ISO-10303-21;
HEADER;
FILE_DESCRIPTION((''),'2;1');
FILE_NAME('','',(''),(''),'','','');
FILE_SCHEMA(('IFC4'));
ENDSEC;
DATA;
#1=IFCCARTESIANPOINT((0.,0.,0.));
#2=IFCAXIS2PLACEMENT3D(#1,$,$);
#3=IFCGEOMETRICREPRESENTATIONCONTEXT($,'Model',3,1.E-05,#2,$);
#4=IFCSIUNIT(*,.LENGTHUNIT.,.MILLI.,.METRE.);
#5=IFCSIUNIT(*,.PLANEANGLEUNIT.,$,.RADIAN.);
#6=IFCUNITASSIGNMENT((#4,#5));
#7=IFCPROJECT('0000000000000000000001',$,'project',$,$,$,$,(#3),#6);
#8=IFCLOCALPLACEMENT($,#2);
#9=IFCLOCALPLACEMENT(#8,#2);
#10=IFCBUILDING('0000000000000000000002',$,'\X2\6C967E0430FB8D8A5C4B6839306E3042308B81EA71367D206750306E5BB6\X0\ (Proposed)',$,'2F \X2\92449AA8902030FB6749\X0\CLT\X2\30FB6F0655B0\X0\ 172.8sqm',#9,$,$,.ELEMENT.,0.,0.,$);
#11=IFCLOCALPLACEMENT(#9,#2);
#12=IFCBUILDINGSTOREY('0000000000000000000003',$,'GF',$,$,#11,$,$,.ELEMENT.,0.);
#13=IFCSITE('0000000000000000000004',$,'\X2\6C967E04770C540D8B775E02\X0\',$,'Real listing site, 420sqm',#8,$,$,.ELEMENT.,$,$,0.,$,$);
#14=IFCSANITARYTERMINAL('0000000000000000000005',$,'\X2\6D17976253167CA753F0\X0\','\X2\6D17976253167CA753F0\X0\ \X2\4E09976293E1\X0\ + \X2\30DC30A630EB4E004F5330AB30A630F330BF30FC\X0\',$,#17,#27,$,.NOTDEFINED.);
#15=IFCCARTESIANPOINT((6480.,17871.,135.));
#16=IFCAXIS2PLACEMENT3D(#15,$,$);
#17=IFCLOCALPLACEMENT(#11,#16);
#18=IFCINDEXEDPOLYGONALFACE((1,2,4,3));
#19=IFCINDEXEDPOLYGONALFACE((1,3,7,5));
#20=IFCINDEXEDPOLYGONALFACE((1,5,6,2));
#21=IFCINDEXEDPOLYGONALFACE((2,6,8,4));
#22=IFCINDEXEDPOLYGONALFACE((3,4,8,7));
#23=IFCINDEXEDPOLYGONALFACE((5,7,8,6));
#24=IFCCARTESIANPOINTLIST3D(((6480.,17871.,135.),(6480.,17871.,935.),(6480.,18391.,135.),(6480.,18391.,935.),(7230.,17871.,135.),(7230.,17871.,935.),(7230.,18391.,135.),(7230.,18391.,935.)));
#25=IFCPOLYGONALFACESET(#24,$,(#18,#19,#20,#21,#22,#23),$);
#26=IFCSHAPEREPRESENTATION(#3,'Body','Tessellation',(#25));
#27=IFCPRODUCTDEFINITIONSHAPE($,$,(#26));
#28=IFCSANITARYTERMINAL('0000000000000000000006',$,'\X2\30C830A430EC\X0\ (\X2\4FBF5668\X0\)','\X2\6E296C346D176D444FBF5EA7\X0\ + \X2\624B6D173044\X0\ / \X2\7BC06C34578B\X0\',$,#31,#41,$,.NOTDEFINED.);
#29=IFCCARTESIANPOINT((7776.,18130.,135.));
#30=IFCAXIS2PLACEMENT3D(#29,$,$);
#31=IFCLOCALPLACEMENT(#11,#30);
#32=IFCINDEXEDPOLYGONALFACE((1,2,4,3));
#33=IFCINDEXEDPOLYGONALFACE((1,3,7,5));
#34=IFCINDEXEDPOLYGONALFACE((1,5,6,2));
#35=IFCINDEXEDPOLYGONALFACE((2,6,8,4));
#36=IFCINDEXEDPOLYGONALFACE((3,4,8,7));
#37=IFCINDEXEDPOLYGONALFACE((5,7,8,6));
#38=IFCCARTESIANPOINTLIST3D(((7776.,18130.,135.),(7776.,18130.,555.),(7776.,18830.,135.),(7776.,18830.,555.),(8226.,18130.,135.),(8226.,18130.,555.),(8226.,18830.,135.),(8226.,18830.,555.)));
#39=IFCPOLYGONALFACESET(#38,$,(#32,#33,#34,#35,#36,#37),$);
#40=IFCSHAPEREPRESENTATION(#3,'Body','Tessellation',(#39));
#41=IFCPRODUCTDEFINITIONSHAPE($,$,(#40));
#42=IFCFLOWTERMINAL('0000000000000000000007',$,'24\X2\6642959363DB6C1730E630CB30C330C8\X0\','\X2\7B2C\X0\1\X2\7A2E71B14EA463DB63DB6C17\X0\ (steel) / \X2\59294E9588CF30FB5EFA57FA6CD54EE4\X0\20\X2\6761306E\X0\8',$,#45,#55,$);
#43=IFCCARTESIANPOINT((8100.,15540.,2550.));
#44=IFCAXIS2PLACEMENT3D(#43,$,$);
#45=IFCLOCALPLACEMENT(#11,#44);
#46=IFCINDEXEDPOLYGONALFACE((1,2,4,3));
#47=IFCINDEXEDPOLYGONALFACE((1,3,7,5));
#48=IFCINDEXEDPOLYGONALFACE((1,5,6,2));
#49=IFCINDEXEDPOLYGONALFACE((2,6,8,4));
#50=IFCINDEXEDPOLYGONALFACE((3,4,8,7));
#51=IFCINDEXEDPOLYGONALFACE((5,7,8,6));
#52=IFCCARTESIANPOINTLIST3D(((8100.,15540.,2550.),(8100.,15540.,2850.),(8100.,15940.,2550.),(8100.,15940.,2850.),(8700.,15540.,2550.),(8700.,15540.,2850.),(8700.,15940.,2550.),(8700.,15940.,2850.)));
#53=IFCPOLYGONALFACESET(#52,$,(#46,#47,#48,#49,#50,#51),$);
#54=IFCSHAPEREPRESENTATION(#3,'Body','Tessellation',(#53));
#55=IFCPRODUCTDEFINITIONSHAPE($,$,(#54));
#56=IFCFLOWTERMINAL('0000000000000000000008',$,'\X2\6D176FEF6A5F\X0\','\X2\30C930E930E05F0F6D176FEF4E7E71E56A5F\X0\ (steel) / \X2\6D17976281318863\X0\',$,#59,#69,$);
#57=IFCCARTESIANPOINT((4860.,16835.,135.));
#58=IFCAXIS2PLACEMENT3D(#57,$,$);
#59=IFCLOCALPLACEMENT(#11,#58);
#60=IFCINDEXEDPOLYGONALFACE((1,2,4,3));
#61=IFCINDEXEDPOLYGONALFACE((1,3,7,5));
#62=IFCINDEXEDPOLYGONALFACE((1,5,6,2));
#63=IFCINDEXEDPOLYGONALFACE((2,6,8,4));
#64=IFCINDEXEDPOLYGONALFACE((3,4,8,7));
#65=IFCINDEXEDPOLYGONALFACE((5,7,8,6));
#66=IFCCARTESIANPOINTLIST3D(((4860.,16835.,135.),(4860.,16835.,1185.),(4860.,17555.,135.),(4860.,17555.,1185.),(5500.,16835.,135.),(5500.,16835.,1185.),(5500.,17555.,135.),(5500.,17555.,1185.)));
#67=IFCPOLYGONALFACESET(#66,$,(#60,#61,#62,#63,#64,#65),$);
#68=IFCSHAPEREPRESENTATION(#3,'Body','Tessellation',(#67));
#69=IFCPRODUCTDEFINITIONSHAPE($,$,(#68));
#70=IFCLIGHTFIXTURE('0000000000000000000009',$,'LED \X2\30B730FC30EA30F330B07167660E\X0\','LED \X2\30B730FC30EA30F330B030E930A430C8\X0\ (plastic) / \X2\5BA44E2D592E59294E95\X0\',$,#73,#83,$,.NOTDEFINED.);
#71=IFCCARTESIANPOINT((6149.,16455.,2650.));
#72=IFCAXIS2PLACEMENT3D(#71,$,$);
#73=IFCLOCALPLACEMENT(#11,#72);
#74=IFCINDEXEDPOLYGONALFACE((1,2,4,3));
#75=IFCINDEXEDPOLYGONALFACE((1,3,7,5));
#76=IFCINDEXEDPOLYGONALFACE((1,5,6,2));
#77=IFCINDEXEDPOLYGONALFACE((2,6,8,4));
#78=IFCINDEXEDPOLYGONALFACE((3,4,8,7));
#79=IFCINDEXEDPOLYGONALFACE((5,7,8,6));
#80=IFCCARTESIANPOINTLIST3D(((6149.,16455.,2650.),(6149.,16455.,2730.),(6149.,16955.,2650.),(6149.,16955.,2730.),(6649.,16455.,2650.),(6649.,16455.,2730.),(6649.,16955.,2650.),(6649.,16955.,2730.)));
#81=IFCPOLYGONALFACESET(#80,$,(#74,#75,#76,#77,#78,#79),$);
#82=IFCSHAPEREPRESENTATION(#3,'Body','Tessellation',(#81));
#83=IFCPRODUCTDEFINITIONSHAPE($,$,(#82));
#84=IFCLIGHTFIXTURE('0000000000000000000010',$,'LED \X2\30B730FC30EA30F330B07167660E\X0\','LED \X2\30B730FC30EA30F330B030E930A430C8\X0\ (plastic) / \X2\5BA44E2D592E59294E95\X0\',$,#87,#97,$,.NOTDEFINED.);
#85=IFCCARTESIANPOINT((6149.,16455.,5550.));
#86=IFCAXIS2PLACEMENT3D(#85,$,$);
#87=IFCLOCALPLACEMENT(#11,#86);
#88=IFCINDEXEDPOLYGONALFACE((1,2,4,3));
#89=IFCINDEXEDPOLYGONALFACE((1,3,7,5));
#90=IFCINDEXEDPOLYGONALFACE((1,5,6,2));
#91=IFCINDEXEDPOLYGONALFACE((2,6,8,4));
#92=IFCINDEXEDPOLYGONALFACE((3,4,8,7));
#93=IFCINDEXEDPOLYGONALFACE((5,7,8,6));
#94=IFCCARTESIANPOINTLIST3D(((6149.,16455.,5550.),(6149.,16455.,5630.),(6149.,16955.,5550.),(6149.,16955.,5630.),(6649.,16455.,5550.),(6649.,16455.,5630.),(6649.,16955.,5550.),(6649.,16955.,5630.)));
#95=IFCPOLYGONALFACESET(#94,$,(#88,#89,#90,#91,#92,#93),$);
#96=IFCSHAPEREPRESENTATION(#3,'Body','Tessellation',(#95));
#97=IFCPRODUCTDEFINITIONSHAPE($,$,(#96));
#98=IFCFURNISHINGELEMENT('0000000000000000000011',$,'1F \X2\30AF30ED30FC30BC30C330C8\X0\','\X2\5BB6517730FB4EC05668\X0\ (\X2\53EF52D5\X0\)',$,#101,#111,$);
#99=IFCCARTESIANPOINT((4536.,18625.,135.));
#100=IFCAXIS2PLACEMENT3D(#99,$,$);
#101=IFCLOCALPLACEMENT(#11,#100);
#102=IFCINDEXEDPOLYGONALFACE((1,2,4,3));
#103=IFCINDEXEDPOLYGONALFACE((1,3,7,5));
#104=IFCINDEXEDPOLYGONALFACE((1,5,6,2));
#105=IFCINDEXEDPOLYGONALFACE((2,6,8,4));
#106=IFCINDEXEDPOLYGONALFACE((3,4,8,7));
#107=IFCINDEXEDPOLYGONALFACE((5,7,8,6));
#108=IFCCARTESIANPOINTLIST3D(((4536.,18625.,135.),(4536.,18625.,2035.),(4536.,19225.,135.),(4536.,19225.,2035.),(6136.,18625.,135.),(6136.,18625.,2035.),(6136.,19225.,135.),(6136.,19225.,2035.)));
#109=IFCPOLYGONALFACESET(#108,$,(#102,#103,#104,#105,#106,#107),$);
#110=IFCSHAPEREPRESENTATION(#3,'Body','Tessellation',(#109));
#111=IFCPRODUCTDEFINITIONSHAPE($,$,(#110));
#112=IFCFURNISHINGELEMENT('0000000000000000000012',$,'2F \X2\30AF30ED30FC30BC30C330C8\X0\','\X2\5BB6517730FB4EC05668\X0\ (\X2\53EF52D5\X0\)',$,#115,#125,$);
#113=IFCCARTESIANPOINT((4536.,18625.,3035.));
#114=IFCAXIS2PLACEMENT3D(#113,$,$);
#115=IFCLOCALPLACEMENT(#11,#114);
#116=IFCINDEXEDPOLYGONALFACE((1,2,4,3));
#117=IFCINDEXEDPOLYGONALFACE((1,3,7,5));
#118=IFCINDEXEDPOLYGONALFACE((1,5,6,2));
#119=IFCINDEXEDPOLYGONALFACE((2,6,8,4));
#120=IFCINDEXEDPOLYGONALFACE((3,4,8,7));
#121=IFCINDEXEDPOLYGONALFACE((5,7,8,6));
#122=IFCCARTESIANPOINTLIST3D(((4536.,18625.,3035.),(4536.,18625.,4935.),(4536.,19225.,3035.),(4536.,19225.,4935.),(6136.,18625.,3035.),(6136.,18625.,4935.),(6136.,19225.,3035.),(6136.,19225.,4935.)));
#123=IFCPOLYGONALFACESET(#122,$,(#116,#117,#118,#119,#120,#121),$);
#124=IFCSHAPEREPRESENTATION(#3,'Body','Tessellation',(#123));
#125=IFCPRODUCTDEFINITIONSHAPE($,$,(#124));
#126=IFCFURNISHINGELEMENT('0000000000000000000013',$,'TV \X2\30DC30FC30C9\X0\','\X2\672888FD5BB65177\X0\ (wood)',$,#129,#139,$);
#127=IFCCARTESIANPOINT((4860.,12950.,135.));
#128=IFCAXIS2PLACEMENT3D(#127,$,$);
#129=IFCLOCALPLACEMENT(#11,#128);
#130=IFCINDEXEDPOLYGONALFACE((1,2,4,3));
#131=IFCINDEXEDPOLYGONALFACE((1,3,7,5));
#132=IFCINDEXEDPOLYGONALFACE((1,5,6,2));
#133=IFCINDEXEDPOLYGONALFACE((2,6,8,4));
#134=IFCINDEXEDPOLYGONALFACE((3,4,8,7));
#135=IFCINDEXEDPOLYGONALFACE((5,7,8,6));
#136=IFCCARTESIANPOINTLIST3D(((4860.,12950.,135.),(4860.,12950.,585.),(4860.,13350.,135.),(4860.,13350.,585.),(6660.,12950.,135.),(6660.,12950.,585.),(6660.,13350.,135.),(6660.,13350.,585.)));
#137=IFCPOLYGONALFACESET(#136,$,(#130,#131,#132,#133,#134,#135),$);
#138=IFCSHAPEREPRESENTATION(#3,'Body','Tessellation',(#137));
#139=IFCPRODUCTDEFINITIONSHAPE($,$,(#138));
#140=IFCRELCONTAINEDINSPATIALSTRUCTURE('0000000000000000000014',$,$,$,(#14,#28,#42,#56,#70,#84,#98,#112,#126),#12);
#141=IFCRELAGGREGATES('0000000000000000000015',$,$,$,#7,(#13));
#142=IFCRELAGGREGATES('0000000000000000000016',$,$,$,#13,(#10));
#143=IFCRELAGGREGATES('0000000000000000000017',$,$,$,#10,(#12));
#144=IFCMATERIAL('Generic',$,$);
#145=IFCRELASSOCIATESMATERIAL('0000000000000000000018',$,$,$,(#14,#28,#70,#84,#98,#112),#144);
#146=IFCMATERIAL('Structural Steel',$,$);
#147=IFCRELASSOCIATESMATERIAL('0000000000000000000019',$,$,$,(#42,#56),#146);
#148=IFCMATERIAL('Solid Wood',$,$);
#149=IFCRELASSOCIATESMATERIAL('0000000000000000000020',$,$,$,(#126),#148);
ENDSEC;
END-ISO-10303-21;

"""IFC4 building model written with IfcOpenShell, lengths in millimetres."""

from ifc_helpers import new_model, si_unit, frame, frame_2d, origin, place, context, project, spatial, rectangle, extrude, material, element, save


model = new_model("IFC4")

# Units and contexts
model_context = context("Model", 3, precision=1e-05, world=origin())
ifc_project = project(units=[si_unit("LENGTHUNIT", "METRE", prefix="MILLI"), si_unit("PLANEANGLEUNIT", "RADIAN")], contexts=[model_context])

# Site, building, storey
site_placement = place(None, origin())
site = spatial("IfcSite", under=ifc_project, at=site_placement, Name="沖縄県名護市", ObjectType="Real listing site, 420sqm", CompositionType="ELEMENT", RefElevation=0.0)
building_placement = place(site_placement, origin())
building = spatial("IfcBuilding", under=site, at=building_placement, Name="沖縄・越屋根のある自然素材の家 (Proposed)", ObjectType="2F 鉄骨造・杉CLT・漆喰 172.8sqm", CompositionType="ELEMENT", ElevationOfRefHeight=0.0, ElevationOfTerrain=0.0)
storey_placement = place(building_placement, origin())
storey = spatial("IfcBuildingStorey", under=building, at=storey_placement, Name="GF", CompositionType="ELEMENT", Elevation=0.0)

# Shared definitions
ifc_material_1 = material(Name="Solid Wood")

# Sanitary terminals
ifc_material_2 = material(Name="Generic")
sanitary_terminal_1_placement = place(storey_placement, frame((6480.0, 17871.0, 135.0)))
element("IfcSanitaryTerminal", 1, at=sanitary_terminal_1_placement, inside=storey, material=ifc_material_2, Name="洗面化粧台", Description="洗面化粧台 三面鏡 + ボウル一体カウンター", PredefinedType="NOTDEFINED", context=model_context, shape_type="SweptSolid", body=[
    extrude(rectangle(XDim=750.0, YDim=520.0, at=frame_2d((375.0, 260.0))), frame((6480.0, 17871.0, 135.0)), (0.0, 0.0, 1.0), 800.0),
])
sanitary_terminal_2_placement = place(storey_placement, frame((7776.0, 18130.0, 135.0)))
element("IfcSanitaryTerminal", 2, at=sanitary_terminal_2_placement, inside=storey, material=ifc_material_2, Name="トイレ (便器)", Description="温水洗浄便座 + 手洗い / 節水型", PredefinedType="NOTDEFINED", context=model_context, shape_type="SweptSolid", body=[
    extrude(rectangle(XDim=450.0, YDim=700.0, at=frame_2d((225.0, 350.0))), frame((7776.0, 18130.0, 135.0)), (0.0, 0.0, 1.0), 420.0),
])

# Flow terminals
ifc_material_3 = material(Name="Structural Steel")
flow_terminal_1_placement = place(storey_placement, frame((8100.0, 15540.0, 2550.0)))
element("IfcFlowTerminal", 3, at=flow_terminal_1_placement, inside=storey, material=ifc_material_3, Name="24時間換気ユニット", Description="第1種熱交換換気 (steel) / 天井裏・建基法令20条の8", context=model_context, shape_type="SweptSolid", body=[
    extrude(rectangle(XDim=600.0, YDim=400.0, at=frame_2d((300.0, 200.0))), frame((8100.0, 15540.0, 2550.0)), (0.0, 0.0, 1.0), 300.0),
])
flow_terminal_2_placement = place(storey_placement, frame((4860.0, 16835.0, 135.0)))
element("IfcFlowTerminal", 4, at=flow_terminal_2_placement, inside=storey, material=ifc_material_3, Name="洗濯機", Description="ドラム式洗濯乾燥機 (steel) / 洗面脱衣", context=model_context, shape_type="SweptSolid", body=[
    extrude(rectangle(XDim=640.0, YDim=720.0, at=frame_2d((320.0, 360.0))), frame((4860.0, 16835.0, 135.0)), (0.0, 0.0, 1.0), 1050.0),
])

# Light fixtures
light_fixture_1_placement = place(storey_placement, frame((6149.0, 16455.0, 2650.0)))
element("IfcLightFixture", 5, at=light_fixture_1_placement, inside=storey, material=ifc_material_2, Name="LED シーリング照明", Description="LED シーリングライト (plastic) / 室中央天井", PredefinedType="NOTDEFINED", context=model_context, shape_type="SweptSolid", body=[
    extrude(rectangle(XDim=500.0, YDim=500.0, at=frame_2d((250.0, 250.0))), frame((6149.0, 16455.0, 2650.0)), (0.0, 0.0, 1.0), 80.0),
])
light_fixture_2_placement = place(storey_placement, frame((6149.0, 16455.0, 5550.0)))
element("IfcLightFixture", 6, at=light_fixture_2_placement, inside=storey, material=ifc_material_2, Name="LED シーリング照明", Description="LED シーリングライト (plastic) / 室中央天井", PredefinedType="NOTDEFINED", context=model_context, shape_type="SweptSolid", body=[
    extrude(rectangle(XDim=500.0, YDim=500.0, at=frame_2d((250.0, 250.0))), frame((6149.0, 16455.0, 5550.0)), (0.0, 0.0, 1.0), 80.0),
])

# Furnishing elements
furnishing_1_placement = place(storey_placement, frame((4536.0, 18625.0, 135.0)))
element("IfcFurnishingElement", 7, at=furnishing_1_placement, inside=storey, material=ifc_material_2, Name="1F クローゼット", Description="家具・什器 (可動)", context=model_context, shape_type="SweptSolid", body=[
    extrude(rectangle(XDim=1600.0, YDim=600.0, at=frame_2d((800.0, 300.0))), frame((4536.0, 18625.0, 135.0)), (0.0, 0.0, 1.0), 1900.0),
])
furnishing_2_placement = place(storey_placement, frame((4536.0, 18625.0, 3035.0)))
element("IfcFurnishingElement", 8, at=furnishing_2_placement, inside=storey, material=ifc_material_2, Name="2F クローゼット", Description="家具・什器 (可動)", context=model_context, shape_type="SweptSolid", body=[
    extrude(rectangle(XDim=1600.0, YDim=600.0, at=frame_2d((800.0, 300.0))), frame((4536.0, 18625.0, 3035.0)), (0.0, 0.0, 1.0), 1900.0),
])
furnishing_3_placement = place(storey_placement, frame((4860.0, 12950.0, 135.0)))
element("IfcFurnishingElement", 9, at=furnishing_3_placement, inside=storey, material=ifc_material_1, Name="TV ボード", Description="木製家具 (wood)", context=model_context, shape_type="SweptSolid", body=[
    extrude(rectangle(XDim=1800.0, YDim=400.0, at=frame_2d((900.0, 200.0))), frame((4860.0, 12950.0, 135.0)), (0.0, 0.0, 1.0), 450.0),
])

save(model, "model.ifc")
